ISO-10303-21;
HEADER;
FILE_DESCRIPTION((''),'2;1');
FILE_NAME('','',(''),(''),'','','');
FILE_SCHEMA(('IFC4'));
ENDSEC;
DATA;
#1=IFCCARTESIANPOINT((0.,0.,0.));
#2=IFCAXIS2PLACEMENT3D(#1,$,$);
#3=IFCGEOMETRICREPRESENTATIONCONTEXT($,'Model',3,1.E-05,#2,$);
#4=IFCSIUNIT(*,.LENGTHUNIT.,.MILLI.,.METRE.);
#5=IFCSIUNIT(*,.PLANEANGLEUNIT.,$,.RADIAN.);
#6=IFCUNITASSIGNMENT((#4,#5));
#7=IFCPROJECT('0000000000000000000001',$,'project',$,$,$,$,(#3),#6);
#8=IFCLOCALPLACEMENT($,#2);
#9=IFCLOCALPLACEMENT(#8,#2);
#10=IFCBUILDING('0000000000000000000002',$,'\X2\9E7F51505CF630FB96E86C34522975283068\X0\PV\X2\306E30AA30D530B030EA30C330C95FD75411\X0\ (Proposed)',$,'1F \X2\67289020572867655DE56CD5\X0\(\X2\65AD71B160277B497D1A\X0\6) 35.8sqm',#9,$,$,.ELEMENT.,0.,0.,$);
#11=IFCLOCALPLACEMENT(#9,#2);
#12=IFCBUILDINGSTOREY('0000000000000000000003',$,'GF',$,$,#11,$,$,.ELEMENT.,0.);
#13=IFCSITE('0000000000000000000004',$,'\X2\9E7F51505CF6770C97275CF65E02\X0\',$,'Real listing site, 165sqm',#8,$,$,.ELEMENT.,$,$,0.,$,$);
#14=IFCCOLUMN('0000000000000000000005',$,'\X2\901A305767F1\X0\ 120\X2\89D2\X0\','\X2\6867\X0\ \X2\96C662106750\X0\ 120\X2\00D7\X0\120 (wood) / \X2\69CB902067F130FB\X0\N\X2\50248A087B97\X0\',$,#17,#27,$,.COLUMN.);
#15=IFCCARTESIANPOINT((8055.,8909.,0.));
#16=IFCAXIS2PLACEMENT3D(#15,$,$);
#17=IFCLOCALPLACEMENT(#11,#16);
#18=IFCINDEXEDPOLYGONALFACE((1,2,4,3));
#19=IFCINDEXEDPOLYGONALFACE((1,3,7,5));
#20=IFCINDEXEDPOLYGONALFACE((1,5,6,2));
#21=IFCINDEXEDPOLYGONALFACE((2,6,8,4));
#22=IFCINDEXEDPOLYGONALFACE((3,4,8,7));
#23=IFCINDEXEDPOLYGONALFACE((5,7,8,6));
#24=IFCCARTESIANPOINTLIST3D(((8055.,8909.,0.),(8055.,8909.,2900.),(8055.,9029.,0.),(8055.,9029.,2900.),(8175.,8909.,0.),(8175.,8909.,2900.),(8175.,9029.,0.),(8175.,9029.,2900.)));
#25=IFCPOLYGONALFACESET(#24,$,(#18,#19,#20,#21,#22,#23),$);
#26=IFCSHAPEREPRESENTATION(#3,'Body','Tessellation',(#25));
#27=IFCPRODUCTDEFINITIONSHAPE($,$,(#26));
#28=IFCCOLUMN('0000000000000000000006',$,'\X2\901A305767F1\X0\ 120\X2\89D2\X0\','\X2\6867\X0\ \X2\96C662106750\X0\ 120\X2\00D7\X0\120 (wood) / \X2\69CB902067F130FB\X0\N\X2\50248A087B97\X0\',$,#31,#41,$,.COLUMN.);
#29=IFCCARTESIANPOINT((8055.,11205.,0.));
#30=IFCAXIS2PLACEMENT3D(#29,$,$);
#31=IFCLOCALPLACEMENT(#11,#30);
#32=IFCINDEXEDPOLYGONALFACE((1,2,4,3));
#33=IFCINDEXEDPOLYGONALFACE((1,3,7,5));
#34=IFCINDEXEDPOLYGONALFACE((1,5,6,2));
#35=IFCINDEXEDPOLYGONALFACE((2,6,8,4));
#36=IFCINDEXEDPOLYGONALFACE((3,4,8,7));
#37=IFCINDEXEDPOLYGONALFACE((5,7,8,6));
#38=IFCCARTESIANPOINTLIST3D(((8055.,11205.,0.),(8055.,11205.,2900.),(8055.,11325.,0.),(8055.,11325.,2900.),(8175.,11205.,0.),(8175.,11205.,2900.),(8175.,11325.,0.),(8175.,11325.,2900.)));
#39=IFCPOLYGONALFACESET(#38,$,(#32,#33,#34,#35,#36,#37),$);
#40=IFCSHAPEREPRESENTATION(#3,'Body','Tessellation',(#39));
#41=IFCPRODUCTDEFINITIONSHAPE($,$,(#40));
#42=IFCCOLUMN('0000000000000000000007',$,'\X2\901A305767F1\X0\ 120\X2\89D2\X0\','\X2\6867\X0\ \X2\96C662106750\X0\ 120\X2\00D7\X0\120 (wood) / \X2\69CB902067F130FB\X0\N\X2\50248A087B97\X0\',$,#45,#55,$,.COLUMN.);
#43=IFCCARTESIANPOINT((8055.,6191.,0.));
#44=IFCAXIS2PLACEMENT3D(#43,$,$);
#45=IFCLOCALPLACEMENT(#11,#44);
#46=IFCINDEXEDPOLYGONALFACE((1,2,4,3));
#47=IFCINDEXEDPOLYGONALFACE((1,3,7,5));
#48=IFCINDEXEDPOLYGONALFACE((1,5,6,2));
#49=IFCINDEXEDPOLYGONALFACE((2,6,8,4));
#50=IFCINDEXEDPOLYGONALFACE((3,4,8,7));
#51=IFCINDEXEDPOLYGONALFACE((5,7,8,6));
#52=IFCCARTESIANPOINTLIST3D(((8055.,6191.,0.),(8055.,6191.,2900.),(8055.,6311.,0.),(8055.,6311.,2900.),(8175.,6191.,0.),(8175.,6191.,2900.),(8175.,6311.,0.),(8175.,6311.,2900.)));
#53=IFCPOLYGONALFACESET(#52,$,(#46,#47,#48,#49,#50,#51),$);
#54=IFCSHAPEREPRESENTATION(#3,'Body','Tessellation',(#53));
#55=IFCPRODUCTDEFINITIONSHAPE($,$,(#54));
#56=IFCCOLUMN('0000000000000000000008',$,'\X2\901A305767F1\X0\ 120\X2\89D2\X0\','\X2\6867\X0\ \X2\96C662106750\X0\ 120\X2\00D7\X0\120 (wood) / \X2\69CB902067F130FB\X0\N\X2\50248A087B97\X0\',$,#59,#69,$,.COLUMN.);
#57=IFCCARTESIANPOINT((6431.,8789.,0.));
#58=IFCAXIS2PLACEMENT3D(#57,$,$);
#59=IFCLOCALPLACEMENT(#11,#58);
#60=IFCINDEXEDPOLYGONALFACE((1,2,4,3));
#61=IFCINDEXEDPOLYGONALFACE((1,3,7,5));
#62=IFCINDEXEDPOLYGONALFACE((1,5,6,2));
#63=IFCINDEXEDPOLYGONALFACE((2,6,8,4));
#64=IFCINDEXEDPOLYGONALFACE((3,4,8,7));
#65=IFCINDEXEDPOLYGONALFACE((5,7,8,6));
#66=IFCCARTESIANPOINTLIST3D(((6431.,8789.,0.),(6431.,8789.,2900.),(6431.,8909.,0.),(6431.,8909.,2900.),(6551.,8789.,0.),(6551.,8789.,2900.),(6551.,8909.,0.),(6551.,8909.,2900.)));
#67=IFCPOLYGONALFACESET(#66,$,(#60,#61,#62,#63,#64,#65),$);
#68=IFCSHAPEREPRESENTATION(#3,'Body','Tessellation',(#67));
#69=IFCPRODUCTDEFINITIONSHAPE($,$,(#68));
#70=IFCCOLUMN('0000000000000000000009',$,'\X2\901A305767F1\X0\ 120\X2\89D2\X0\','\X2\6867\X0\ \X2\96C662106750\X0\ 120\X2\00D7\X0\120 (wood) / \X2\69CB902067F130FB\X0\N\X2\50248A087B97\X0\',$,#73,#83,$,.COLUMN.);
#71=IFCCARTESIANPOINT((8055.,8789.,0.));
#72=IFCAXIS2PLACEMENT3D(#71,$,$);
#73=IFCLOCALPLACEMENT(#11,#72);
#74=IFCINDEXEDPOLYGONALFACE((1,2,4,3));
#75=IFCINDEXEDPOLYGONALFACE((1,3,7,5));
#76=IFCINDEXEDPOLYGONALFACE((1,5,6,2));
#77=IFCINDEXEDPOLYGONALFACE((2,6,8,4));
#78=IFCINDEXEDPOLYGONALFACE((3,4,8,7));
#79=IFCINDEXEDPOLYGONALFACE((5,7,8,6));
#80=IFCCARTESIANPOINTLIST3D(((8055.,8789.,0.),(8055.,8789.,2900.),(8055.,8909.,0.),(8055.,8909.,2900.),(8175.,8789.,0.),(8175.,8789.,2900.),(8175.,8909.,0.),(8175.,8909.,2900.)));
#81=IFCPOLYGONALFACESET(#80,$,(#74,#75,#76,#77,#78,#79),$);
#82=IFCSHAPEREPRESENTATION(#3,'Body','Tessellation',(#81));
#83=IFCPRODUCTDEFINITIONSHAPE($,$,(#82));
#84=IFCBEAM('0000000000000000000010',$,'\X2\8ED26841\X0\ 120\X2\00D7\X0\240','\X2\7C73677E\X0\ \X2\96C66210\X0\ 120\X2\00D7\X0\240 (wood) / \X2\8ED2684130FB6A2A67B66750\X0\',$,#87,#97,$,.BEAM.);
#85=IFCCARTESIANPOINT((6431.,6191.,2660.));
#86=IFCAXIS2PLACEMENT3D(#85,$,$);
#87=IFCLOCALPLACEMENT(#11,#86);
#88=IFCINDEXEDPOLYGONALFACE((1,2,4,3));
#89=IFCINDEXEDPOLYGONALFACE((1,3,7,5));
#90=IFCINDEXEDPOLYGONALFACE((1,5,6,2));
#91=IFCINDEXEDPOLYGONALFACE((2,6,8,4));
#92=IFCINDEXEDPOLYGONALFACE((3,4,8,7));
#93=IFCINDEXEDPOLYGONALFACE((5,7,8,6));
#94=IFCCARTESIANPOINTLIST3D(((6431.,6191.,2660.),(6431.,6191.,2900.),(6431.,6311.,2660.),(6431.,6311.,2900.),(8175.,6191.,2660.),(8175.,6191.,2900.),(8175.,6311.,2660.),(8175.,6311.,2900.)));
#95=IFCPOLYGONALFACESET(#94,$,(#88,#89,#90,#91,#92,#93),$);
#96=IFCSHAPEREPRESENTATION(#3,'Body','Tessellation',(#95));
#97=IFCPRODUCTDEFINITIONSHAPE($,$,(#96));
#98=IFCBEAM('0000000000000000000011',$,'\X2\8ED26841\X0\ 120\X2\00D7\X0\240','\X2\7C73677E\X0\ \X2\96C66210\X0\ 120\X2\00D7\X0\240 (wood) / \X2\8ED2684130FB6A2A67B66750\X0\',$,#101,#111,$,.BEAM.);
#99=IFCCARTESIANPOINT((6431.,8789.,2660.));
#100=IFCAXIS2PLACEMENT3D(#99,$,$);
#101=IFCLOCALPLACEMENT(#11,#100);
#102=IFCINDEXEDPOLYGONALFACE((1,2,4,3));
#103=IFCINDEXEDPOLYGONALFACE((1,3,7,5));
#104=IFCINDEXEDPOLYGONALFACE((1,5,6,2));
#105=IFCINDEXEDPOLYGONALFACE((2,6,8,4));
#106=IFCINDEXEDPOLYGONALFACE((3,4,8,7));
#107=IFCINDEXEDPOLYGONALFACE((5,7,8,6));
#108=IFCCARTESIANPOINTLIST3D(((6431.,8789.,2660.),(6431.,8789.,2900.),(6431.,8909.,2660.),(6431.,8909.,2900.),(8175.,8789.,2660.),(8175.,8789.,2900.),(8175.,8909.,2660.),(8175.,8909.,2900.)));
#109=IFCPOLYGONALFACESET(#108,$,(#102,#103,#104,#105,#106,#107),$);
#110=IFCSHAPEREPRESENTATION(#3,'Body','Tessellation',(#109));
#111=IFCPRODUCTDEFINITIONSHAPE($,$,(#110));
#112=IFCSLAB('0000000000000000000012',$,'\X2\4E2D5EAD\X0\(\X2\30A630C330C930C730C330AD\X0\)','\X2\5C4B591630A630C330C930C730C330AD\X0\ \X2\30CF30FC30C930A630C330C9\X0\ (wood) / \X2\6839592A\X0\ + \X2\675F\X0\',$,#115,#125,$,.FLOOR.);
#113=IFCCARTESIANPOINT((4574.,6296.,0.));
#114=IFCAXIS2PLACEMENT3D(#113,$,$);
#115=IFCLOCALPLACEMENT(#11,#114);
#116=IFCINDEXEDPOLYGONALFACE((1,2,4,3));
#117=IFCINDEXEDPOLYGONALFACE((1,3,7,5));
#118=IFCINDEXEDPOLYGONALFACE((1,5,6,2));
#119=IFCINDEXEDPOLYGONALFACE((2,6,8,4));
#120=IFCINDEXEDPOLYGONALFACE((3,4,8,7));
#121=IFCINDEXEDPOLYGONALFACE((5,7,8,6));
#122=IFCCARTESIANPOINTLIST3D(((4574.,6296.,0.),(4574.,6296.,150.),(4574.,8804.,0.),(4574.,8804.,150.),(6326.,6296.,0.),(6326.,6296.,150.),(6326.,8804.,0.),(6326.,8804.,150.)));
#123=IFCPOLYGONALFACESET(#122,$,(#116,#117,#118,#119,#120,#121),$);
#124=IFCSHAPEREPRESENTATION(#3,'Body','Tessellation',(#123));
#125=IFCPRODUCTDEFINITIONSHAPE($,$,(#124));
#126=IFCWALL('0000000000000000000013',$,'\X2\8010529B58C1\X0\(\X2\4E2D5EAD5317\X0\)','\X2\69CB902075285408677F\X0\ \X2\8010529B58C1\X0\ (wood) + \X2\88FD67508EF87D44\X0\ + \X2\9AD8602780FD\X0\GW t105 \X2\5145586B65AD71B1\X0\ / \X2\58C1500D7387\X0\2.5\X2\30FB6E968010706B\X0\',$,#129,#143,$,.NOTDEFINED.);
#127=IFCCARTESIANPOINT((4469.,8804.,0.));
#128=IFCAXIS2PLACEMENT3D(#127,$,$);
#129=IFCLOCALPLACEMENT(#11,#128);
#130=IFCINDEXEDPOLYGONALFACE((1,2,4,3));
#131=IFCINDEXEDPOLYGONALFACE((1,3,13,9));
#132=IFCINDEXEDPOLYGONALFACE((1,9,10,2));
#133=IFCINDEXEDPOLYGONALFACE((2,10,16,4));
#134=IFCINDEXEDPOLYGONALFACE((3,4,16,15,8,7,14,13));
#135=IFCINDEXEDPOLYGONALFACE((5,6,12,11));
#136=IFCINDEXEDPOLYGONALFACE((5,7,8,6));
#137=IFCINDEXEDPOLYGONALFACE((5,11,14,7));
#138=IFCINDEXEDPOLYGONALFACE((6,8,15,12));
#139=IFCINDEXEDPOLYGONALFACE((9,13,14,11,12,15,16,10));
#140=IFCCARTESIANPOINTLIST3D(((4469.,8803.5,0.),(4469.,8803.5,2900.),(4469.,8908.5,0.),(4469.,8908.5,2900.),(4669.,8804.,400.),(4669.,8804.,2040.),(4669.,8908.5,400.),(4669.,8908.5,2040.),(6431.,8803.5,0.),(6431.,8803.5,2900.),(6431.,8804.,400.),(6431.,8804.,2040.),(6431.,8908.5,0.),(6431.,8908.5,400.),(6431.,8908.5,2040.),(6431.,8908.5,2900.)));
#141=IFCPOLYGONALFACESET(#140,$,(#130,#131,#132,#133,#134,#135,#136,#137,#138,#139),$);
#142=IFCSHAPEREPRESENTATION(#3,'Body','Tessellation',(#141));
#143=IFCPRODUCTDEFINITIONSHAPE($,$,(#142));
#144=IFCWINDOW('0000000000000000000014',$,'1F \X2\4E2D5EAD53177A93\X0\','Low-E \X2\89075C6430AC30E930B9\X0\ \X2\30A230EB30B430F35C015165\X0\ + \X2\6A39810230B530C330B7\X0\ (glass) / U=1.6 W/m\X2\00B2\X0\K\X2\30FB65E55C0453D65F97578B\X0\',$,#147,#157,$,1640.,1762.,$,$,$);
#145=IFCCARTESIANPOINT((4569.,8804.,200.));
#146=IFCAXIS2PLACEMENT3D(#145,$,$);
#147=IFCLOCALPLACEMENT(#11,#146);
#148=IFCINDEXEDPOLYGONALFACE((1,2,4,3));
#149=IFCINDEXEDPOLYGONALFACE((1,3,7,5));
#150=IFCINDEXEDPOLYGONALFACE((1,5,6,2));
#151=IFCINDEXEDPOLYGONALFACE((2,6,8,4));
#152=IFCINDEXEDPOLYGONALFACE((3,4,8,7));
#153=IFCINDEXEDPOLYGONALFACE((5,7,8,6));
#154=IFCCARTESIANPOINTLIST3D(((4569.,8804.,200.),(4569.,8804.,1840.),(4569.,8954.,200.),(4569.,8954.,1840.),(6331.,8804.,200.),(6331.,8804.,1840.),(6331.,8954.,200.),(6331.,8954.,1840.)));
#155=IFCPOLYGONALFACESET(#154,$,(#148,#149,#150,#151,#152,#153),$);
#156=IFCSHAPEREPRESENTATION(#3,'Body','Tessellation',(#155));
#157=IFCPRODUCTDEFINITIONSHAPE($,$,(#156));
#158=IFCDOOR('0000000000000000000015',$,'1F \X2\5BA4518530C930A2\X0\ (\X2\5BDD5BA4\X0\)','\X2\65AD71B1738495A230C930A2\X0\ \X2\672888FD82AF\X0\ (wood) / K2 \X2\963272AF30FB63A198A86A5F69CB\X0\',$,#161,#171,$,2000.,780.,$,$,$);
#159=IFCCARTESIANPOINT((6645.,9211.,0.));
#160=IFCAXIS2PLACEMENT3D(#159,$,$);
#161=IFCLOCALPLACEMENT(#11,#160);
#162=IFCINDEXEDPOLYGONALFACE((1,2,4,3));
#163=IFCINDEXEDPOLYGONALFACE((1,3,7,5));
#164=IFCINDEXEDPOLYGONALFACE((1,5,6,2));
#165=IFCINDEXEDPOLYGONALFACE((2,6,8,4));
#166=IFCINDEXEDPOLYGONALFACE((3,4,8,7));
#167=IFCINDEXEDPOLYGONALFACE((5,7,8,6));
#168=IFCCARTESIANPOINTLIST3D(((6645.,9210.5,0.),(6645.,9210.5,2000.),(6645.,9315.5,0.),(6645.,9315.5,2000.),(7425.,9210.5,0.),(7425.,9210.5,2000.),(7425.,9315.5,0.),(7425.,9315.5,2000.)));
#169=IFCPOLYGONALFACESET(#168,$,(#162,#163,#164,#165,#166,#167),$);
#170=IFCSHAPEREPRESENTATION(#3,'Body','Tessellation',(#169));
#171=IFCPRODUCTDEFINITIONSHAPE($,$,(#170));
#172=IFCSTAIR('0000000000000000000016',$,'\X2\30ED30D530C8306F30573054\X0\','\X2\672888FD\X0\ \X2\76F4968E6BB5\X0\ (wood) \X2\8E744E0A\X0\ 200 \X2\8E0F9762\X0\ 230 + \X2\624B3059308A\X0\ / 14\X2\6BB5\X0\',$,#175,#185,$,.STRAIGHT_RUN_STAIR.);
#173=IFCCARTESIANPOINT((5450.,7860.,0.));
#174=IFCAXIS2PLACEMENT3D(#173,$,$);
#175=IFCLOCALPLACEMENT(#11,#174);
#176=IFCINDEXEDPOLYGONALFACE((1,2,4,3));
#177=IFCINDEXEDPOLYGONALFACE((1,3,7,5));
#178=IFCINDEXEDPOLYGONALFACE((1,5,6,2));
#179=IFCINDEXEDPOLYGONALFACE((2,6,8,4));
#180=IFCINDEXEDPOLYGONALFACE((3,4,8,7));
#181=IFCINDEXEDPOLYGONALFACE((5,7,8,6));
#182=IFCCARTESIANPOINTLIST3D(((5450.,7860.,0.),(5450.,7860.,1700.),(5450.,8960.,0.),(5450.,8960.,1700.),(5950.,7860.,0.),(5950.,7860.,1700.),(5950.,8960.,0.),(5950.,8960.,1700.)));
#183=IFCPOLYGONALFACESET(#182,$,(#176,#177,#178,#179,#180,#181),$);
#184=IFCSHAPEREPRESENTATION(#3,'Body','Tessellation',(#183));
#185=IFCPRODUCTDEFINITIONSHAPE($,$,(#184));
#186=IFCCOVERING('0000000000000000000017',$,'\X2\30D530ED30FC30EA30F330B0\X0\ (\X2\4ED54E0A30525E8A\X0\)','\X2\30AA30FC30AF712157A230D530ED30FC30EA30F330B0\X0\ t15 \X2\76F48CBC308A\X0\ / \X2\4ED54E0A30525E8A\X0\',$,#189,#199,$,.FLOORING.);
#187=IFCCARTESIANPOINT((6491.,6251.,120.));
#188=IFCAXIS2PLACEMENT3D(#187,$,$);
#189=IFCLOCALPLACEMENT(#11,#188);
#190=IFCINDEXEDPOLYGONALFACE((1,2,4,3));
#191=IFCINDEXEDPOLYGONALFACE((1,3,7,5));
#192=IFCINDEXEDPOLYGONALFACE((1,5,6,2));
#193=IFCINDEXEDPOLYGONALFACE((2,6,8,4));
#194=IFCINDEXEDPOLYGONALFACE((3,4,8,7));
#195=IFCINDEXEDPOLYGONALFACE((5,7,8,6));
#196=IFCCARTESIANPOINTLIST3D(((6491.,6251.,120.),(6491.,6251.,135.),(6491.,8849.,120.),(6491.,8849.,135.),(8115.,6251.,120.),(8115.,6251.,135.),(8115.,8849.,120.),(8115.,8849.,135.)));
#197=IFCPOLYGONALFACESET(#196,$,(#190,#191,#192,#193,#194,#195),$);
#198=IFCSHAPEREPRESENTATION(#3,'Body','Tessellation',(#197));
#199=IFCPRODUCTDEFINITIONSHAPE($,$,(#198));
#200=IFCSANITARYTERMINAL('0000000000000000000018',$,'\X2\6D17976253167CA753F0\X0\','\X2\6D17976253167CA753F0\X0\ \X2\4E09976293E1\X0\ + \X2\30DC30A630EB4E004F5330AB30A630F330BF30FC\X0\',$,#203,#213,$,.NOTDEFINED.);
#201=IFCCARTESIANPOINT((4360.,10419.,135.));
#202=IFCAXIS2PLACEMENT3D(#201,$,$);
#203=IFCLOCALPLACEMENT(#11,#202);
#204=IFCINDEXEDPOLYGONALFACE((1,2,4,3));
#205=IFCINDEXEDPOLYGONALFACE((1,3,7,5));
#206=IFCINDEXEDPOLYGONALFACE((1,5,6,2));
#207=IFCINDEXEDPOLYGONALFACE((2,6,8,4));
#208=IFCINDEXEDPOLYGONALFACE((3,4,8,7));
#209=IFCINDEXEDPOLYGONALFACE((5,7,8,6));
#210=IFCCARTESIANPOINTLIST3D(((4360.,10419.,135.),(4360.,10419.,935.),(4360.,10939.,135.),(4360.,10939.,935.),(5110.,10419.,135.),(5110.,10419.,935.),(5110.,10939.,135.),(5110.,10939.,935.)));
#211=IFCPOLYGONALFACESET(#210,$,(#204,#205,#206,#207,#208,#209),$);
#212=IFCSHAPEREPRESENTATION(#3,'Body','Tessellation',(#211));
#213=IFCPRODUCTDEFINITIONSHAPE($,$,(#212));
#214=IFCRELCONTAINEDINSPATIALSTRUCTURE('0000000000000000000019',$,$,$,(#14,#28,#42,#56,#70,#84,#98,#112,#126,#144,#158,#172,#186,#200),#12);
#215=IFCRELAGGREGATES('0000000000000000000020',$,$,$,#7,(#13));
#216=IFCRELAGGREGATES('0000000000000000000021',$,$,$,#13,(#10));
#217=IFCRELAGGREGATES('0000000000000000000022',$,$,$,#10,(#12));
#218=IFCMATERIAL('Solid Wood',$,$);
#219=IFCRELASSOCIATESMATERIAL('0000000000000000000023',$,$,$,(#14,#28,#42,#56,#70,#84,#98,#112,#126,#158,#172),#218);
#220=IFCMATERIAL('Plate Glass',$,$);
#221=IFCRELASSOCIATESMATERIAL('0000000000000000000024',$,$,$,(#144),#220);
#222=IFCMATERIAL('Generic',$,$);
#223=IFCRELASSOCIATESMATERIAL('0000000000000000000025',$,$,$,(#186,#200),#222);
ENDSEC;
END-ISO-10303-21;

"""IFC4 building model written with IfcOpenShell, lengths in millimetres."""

from ifc_helpers import new_model, si_unit, frame, frame_2d, origin, place, context, project, spatial, rectangle, extrude, material, element, fill, save


model = new_model("IFC4")

# Units and contexts
model_context = context("Model", 3, precision=1e-05, world=origin())
ifc_project = project(units=[si_unit("LENGTHUNIT", "METRE", prefix="MILLI"), si_unit("PLANEANGLEUNIT", "RADIAN")], contexts=[model_context])

# Site, building, storey
site_placement = place(None, origin())
site = spatial("IfcSite", under=ifc_project, at=site_placement, Name="鹿児島県霧島市", ObjectType="Real listing site, 165sqm", CompositionType="ELEMENT", RefElevation=0.0)
building_placement = place(site_placement, origin())
building = spatial("IfcBuilding", under=site, at=building_placement, Name="鹿児島・雨水利用とPVのオフグリッド志向 (Proposed)", ObjectType="1F 木造在来工法(断熱性等級6) 35.8sqm", CompositionType="ELEMENT", ElevationOfRefHeight=0.0, ElevationOfTerrain=0.0)
storey_placement = place(building_placement, origin())
storey = spatial("IfcBuildingStorey", under=building, at=storey_placement, Name="GF", CompositionType="ELEMENT", Elevation=0.0)

# Columns
ifc_material_1 = material(Name="Solid Wood")
column_1_placement = place(storey_placement, frame((8055.0, 8909.0, 0.0)))
element("IfcColumn", 1, at=column_1_placement, inside=storey, material=ifc_material_1, Name="通し柱 120角", Description="桧 集成材 120×120 (wood) / 構造柱・N値計算", PredefinedType="COLUMN", context=model_context, shape_type="SweptSolid", body=[
    extrude(rectangle(XDim=120.0, YDim=120.0, at=frame_2d((60.0, 60.0))), frame((8055.0, 8909.0, 0.0)), (0.0, 0.0, 1.0), 2900.0),
])
column_2_placement = place(storey_placement, frame((8055.0, 11205.0, 0.0)))
element("IfcColumn", 2, at=column_2_placement, inside=storey, material=ifc_material_1, Name="通し柱 120角", Description="桧 集成材 120×120 (wood) / 構造柱・N値計算", PredefinedType="COLUMN", context=model_context, shape_type="SweptSolid", body=[
    extrude(rectangle(XDim=120.0, YDim=120.0, at=frame_2d((60.0, 60.0))), frame((8055.0, 11205.0, 0.0)), (0.0, 0.0, 1.0), 2900.0),
])
column_3_placement = place(storey_placement, frame((8055.0, 6191.0, 0.0)))
element("IfcColumn", 3, at=column_3_placement, inside=storey, material=ifc_material_1, Name="通し柱 120角", Description="桧 集成材 120×120 (wood) / 構造柱・N値計算", PredefinedType="COLUMN", context=model_context, shape_type="SweptSolid", body=[
    extrude(rectangle(XDim=120.0, YDim=120.0, at=frame_2d((60.0, 60.0))), frame((8055.0, 6191.0, 0.0)), (0.0, 0.0, 1.0), 2900.0),
])
column_4_placement = place(storey_placement, frame((6431.0, 8789.0, 0.0)))
element("IfcColumn", 4, at=column_4_placement, inside=storey, material=ifc_material_1, Name="通し柱 120角", Description="桧 集成材 120×120 (wood) / 構造柱・N値計算", PredefinedType="COLUMN", context=model_context, shape_type="SweptSolid", body=[
    extrude(rectangle(XDim=120.0, YDim=120.0, at=frame_2d((60.0, 60.0))), frame((6431.0, 8789.0, 0.0)), (0.0, 0.0, 1.0), 2900.0),
])
column_5_placement = place(storey_placement, frame((8055.0, 8789.0, 0.0)))
element("IfcColumn", 5, at=column_5_placement, inside=storey, material=ifc_material_1, Name="通し柱 120角", Description="桧 集成材 120×120 (wood) / 構造柱・N値計算", PredefinedType="COLUMN", context=model_context, shape_type="SweptSolid", body=[
    extrude(rectangle(XDim=120.0, YDim=120.0, at=frame_2d((60.0, 60.0))), frame((8055.0, 8789.0, 0.0)), (0.0, 0.0, 1.0), 2900.0),
])

# Beams
beam_1_placement = place(storey_placement, frame((6431.0, 6191.0, 2660.0)))
element("IfcBeam", 6, at=beam_1_placement, inside=storey, material=ifc_material_1, Name="軒桁 120×240", Description="米松 集成 120×240 (wood) / 軒桁・横架材", PredefinedType="BEAM", context=model_context, shape_type="SweptSolid", body=[
    extrude(rectangle(XDim=1744.0, YDim=120.0, at=frame_2d((872.0, 60.0))), frame((6431.0, 6191.0, 2660.0)), (0.0, 0.0, 1.0), 240.0),
])
beam_2_placement = place(storey_placement, frame((6431.0, 8789.0, 2660.0)))
element("IfcBeam", 7, at=beam_2_placement, inside=storey, material=ifc_material_1, Name="軒桁 120×240", Description="米松 集成 120×240 (wood) / 軒桁・横架材", PredefinedType="BEAM", context=model_context, shape_type="SweptSolid", body=[
    extrude(rectangle(XDim=1744.0, YDim=120.0, at=frame_2d((872.0, 60.0))), frame((6431.0, 8789.0, 2660.0)), (0.0, 0.0, 1.0), 240.0),
])

# Slab
slab_placement = place(storey_placement, frame((4574.0, 6296.0, 0.0)))
element("IfcSlab", 8, at=slab_placement, inside=storey, material=ifc_material_1, Name="中庭(ウッドデッキ)", Description="屋外ウッドデッキ ハードウッド (wood) / 根太 + 束", PredefinedType="FLOOR", context=model_context, shape_type="SweptSolid", body=[
    extrude(rectangle(XDim=1752.0, YDim=2508.0, at=frame_2d((876.0, 1254.0))), frame((4574.0, 6296.0, 0.0)), (0.0, 0.0, 1.0), 150.0),
])

# Wall, opening, window
wall_1_placement = place(storey_placement, frame((4469.0, 8804.0, 0.0)))
wall_1 = element("IfcWall", 9, at=wall_1_placement, inside=storey, material=ifc_material_1, Name="耐力壁(中庭北)", Description="構造用合板 耐力壁 (wood) + 製材軸組 + 高性能GW t105 充填断熱 / 壁倍率2.5・準耐火", PredefinedType="NOTDEFINED", context=model_context, shape_type="SweptSolid", body=[
    extrude(rectangle(XDim=1962.0, YDim=105.0, at=frame_2d((981.0, 52.0))), frame((4469.0, 8804.0, 0.0)), (0.0, 0.0, 1.0), 2900.0),
])
opening_placement = place(storey_placement, frame((4569.0, 8804.0, 200.0)))
opening = element("IfcOpeningElement", 10, at=opening_placement, cuts=wall_1, PredefinedType="NOTDEFINED", context=model_context, shape_type="SweptSolid", body=[
    extrude(rectangle(XDim=1762.0, YDim=150.0, at=frame_2d((881.0, 75.0))), frame((4569.0, 8804.0, 200.0)), (0.0, 0.0, 1.0), 1640.0),
])
ifc_material_2 = material(Name="Plate Glass")
window_placement = place(storey_placement, frame((4569.0, 8804.0, 200.0)))
window = element("IfcWindow", 11, at=window_placement, inside=storey, material=ifc_material_2, Name="1F 中庭北窓", Description="Low-E 複層ガラス アルゴン封入 + 樹脂サッシ (glass) / U=1.6 W/m²K・日射取得型", OverallHeight=1640.0, OverallWidth=1762.0, context=model_context, shape_type="SweptSolid", body=[
    extrude(rectangle(XDim=1762.0, YDim=150.0, at=frame_2d((881.0, 75.0))), frame((4569.0, 8804.0, 200.0)), (0.0, 0.0, 1.0), 1640.0),
])
fill(opening, window)

# Door
door_placement = place(storey_placement, frame((6645.0, 9211.0, 0.0)))
element("IfcDoor", 12, at=door_placement, inside=storey, material=ifc_material_1, Name="1F 室内ドア (寝室)", Description="断熱玄関ドア 木製芯 (wood) / K2 防犯・採風機構", OverallHeight=2000.0, OverallWidth=780.0, context=model_context, shape_type="SweptSolid", body=[
    extrude(rectangle(XDim=780.0, YDim=105.0, at=frame_2d((390.0, 52.0))), frame((6645.0, 9211.0, 0.0)), (0.0, 0.0, 1.0), 2000.0),
])

# Stair
stair_placement = place(storey_placement, frame((5450.0, 7860.0, 0.0)))
element("IfcStair", 13, at=stair_placement, inside=storey, material=ifc_material_1, Name="ロフトはしご", Description="木製 直階段 (wood) 蹴上 200 踏面 230 + 手すり / 14段", PredefinedType="STRAIGHT_RUN_STAIR", context=model_context, shape_type="SweptSolid", body=[
    extrude(rectangle(XDim=500.0, YDim=1100.0, at=frame_2d((250.0, 550.0))), frame((5450.0, 7860.0, 0.0)), (0.0, 0.0, 1.0), 1700.0),
])

# Covering
ifc_material_3 = material(Name="Generic")
covering_placement = place(storey_placement, frame((6491.0, 6251.0, 120.0)))
element("IfcCovering", 14, at=covering_placement, inside=storey, material=ifc_material_3, Name="フローリング (仕上げ床)", Description="オーク無垢フローリング t15 直貼り / 仕上げ床", PredefinedType="FLOORING", context=model_context, shape_type="SweptSolid", body=[
    extrude(rectangle(XDim=1624.0, YDim=2598.0, at=frame_2d((812.0, 1299.0))), frame((6491.0, 6251.0, 120.0)), (0.0, 0.0, 1.0), 15.0),
])

# Sanitary terminal
sanitary_terminal_1_placement = place(storey_placement, frame((4360.0, 10419.0, 135.0)))
element("IfcSanitaryTerminal", 15, at=sanitary_terminal_1_placement, inside=storey, material=ifc_material_3, Name="洗面化粧台", Description="洗面化粧台 三面鏡 + ボウル一体カウンター", PredefinedType="NOTDEFINED", context=model_context, shape_type="SweptSolid", body=[
    extrude(rectangle(XDim=750.0, YDim=520.0, at=frame_2d((375.0, 260.0))), frame((4360.0, 10419.0, 135.0)), (0.0, 0.0, 1.0), 800.0),
])

save(model, "model.ifc")
